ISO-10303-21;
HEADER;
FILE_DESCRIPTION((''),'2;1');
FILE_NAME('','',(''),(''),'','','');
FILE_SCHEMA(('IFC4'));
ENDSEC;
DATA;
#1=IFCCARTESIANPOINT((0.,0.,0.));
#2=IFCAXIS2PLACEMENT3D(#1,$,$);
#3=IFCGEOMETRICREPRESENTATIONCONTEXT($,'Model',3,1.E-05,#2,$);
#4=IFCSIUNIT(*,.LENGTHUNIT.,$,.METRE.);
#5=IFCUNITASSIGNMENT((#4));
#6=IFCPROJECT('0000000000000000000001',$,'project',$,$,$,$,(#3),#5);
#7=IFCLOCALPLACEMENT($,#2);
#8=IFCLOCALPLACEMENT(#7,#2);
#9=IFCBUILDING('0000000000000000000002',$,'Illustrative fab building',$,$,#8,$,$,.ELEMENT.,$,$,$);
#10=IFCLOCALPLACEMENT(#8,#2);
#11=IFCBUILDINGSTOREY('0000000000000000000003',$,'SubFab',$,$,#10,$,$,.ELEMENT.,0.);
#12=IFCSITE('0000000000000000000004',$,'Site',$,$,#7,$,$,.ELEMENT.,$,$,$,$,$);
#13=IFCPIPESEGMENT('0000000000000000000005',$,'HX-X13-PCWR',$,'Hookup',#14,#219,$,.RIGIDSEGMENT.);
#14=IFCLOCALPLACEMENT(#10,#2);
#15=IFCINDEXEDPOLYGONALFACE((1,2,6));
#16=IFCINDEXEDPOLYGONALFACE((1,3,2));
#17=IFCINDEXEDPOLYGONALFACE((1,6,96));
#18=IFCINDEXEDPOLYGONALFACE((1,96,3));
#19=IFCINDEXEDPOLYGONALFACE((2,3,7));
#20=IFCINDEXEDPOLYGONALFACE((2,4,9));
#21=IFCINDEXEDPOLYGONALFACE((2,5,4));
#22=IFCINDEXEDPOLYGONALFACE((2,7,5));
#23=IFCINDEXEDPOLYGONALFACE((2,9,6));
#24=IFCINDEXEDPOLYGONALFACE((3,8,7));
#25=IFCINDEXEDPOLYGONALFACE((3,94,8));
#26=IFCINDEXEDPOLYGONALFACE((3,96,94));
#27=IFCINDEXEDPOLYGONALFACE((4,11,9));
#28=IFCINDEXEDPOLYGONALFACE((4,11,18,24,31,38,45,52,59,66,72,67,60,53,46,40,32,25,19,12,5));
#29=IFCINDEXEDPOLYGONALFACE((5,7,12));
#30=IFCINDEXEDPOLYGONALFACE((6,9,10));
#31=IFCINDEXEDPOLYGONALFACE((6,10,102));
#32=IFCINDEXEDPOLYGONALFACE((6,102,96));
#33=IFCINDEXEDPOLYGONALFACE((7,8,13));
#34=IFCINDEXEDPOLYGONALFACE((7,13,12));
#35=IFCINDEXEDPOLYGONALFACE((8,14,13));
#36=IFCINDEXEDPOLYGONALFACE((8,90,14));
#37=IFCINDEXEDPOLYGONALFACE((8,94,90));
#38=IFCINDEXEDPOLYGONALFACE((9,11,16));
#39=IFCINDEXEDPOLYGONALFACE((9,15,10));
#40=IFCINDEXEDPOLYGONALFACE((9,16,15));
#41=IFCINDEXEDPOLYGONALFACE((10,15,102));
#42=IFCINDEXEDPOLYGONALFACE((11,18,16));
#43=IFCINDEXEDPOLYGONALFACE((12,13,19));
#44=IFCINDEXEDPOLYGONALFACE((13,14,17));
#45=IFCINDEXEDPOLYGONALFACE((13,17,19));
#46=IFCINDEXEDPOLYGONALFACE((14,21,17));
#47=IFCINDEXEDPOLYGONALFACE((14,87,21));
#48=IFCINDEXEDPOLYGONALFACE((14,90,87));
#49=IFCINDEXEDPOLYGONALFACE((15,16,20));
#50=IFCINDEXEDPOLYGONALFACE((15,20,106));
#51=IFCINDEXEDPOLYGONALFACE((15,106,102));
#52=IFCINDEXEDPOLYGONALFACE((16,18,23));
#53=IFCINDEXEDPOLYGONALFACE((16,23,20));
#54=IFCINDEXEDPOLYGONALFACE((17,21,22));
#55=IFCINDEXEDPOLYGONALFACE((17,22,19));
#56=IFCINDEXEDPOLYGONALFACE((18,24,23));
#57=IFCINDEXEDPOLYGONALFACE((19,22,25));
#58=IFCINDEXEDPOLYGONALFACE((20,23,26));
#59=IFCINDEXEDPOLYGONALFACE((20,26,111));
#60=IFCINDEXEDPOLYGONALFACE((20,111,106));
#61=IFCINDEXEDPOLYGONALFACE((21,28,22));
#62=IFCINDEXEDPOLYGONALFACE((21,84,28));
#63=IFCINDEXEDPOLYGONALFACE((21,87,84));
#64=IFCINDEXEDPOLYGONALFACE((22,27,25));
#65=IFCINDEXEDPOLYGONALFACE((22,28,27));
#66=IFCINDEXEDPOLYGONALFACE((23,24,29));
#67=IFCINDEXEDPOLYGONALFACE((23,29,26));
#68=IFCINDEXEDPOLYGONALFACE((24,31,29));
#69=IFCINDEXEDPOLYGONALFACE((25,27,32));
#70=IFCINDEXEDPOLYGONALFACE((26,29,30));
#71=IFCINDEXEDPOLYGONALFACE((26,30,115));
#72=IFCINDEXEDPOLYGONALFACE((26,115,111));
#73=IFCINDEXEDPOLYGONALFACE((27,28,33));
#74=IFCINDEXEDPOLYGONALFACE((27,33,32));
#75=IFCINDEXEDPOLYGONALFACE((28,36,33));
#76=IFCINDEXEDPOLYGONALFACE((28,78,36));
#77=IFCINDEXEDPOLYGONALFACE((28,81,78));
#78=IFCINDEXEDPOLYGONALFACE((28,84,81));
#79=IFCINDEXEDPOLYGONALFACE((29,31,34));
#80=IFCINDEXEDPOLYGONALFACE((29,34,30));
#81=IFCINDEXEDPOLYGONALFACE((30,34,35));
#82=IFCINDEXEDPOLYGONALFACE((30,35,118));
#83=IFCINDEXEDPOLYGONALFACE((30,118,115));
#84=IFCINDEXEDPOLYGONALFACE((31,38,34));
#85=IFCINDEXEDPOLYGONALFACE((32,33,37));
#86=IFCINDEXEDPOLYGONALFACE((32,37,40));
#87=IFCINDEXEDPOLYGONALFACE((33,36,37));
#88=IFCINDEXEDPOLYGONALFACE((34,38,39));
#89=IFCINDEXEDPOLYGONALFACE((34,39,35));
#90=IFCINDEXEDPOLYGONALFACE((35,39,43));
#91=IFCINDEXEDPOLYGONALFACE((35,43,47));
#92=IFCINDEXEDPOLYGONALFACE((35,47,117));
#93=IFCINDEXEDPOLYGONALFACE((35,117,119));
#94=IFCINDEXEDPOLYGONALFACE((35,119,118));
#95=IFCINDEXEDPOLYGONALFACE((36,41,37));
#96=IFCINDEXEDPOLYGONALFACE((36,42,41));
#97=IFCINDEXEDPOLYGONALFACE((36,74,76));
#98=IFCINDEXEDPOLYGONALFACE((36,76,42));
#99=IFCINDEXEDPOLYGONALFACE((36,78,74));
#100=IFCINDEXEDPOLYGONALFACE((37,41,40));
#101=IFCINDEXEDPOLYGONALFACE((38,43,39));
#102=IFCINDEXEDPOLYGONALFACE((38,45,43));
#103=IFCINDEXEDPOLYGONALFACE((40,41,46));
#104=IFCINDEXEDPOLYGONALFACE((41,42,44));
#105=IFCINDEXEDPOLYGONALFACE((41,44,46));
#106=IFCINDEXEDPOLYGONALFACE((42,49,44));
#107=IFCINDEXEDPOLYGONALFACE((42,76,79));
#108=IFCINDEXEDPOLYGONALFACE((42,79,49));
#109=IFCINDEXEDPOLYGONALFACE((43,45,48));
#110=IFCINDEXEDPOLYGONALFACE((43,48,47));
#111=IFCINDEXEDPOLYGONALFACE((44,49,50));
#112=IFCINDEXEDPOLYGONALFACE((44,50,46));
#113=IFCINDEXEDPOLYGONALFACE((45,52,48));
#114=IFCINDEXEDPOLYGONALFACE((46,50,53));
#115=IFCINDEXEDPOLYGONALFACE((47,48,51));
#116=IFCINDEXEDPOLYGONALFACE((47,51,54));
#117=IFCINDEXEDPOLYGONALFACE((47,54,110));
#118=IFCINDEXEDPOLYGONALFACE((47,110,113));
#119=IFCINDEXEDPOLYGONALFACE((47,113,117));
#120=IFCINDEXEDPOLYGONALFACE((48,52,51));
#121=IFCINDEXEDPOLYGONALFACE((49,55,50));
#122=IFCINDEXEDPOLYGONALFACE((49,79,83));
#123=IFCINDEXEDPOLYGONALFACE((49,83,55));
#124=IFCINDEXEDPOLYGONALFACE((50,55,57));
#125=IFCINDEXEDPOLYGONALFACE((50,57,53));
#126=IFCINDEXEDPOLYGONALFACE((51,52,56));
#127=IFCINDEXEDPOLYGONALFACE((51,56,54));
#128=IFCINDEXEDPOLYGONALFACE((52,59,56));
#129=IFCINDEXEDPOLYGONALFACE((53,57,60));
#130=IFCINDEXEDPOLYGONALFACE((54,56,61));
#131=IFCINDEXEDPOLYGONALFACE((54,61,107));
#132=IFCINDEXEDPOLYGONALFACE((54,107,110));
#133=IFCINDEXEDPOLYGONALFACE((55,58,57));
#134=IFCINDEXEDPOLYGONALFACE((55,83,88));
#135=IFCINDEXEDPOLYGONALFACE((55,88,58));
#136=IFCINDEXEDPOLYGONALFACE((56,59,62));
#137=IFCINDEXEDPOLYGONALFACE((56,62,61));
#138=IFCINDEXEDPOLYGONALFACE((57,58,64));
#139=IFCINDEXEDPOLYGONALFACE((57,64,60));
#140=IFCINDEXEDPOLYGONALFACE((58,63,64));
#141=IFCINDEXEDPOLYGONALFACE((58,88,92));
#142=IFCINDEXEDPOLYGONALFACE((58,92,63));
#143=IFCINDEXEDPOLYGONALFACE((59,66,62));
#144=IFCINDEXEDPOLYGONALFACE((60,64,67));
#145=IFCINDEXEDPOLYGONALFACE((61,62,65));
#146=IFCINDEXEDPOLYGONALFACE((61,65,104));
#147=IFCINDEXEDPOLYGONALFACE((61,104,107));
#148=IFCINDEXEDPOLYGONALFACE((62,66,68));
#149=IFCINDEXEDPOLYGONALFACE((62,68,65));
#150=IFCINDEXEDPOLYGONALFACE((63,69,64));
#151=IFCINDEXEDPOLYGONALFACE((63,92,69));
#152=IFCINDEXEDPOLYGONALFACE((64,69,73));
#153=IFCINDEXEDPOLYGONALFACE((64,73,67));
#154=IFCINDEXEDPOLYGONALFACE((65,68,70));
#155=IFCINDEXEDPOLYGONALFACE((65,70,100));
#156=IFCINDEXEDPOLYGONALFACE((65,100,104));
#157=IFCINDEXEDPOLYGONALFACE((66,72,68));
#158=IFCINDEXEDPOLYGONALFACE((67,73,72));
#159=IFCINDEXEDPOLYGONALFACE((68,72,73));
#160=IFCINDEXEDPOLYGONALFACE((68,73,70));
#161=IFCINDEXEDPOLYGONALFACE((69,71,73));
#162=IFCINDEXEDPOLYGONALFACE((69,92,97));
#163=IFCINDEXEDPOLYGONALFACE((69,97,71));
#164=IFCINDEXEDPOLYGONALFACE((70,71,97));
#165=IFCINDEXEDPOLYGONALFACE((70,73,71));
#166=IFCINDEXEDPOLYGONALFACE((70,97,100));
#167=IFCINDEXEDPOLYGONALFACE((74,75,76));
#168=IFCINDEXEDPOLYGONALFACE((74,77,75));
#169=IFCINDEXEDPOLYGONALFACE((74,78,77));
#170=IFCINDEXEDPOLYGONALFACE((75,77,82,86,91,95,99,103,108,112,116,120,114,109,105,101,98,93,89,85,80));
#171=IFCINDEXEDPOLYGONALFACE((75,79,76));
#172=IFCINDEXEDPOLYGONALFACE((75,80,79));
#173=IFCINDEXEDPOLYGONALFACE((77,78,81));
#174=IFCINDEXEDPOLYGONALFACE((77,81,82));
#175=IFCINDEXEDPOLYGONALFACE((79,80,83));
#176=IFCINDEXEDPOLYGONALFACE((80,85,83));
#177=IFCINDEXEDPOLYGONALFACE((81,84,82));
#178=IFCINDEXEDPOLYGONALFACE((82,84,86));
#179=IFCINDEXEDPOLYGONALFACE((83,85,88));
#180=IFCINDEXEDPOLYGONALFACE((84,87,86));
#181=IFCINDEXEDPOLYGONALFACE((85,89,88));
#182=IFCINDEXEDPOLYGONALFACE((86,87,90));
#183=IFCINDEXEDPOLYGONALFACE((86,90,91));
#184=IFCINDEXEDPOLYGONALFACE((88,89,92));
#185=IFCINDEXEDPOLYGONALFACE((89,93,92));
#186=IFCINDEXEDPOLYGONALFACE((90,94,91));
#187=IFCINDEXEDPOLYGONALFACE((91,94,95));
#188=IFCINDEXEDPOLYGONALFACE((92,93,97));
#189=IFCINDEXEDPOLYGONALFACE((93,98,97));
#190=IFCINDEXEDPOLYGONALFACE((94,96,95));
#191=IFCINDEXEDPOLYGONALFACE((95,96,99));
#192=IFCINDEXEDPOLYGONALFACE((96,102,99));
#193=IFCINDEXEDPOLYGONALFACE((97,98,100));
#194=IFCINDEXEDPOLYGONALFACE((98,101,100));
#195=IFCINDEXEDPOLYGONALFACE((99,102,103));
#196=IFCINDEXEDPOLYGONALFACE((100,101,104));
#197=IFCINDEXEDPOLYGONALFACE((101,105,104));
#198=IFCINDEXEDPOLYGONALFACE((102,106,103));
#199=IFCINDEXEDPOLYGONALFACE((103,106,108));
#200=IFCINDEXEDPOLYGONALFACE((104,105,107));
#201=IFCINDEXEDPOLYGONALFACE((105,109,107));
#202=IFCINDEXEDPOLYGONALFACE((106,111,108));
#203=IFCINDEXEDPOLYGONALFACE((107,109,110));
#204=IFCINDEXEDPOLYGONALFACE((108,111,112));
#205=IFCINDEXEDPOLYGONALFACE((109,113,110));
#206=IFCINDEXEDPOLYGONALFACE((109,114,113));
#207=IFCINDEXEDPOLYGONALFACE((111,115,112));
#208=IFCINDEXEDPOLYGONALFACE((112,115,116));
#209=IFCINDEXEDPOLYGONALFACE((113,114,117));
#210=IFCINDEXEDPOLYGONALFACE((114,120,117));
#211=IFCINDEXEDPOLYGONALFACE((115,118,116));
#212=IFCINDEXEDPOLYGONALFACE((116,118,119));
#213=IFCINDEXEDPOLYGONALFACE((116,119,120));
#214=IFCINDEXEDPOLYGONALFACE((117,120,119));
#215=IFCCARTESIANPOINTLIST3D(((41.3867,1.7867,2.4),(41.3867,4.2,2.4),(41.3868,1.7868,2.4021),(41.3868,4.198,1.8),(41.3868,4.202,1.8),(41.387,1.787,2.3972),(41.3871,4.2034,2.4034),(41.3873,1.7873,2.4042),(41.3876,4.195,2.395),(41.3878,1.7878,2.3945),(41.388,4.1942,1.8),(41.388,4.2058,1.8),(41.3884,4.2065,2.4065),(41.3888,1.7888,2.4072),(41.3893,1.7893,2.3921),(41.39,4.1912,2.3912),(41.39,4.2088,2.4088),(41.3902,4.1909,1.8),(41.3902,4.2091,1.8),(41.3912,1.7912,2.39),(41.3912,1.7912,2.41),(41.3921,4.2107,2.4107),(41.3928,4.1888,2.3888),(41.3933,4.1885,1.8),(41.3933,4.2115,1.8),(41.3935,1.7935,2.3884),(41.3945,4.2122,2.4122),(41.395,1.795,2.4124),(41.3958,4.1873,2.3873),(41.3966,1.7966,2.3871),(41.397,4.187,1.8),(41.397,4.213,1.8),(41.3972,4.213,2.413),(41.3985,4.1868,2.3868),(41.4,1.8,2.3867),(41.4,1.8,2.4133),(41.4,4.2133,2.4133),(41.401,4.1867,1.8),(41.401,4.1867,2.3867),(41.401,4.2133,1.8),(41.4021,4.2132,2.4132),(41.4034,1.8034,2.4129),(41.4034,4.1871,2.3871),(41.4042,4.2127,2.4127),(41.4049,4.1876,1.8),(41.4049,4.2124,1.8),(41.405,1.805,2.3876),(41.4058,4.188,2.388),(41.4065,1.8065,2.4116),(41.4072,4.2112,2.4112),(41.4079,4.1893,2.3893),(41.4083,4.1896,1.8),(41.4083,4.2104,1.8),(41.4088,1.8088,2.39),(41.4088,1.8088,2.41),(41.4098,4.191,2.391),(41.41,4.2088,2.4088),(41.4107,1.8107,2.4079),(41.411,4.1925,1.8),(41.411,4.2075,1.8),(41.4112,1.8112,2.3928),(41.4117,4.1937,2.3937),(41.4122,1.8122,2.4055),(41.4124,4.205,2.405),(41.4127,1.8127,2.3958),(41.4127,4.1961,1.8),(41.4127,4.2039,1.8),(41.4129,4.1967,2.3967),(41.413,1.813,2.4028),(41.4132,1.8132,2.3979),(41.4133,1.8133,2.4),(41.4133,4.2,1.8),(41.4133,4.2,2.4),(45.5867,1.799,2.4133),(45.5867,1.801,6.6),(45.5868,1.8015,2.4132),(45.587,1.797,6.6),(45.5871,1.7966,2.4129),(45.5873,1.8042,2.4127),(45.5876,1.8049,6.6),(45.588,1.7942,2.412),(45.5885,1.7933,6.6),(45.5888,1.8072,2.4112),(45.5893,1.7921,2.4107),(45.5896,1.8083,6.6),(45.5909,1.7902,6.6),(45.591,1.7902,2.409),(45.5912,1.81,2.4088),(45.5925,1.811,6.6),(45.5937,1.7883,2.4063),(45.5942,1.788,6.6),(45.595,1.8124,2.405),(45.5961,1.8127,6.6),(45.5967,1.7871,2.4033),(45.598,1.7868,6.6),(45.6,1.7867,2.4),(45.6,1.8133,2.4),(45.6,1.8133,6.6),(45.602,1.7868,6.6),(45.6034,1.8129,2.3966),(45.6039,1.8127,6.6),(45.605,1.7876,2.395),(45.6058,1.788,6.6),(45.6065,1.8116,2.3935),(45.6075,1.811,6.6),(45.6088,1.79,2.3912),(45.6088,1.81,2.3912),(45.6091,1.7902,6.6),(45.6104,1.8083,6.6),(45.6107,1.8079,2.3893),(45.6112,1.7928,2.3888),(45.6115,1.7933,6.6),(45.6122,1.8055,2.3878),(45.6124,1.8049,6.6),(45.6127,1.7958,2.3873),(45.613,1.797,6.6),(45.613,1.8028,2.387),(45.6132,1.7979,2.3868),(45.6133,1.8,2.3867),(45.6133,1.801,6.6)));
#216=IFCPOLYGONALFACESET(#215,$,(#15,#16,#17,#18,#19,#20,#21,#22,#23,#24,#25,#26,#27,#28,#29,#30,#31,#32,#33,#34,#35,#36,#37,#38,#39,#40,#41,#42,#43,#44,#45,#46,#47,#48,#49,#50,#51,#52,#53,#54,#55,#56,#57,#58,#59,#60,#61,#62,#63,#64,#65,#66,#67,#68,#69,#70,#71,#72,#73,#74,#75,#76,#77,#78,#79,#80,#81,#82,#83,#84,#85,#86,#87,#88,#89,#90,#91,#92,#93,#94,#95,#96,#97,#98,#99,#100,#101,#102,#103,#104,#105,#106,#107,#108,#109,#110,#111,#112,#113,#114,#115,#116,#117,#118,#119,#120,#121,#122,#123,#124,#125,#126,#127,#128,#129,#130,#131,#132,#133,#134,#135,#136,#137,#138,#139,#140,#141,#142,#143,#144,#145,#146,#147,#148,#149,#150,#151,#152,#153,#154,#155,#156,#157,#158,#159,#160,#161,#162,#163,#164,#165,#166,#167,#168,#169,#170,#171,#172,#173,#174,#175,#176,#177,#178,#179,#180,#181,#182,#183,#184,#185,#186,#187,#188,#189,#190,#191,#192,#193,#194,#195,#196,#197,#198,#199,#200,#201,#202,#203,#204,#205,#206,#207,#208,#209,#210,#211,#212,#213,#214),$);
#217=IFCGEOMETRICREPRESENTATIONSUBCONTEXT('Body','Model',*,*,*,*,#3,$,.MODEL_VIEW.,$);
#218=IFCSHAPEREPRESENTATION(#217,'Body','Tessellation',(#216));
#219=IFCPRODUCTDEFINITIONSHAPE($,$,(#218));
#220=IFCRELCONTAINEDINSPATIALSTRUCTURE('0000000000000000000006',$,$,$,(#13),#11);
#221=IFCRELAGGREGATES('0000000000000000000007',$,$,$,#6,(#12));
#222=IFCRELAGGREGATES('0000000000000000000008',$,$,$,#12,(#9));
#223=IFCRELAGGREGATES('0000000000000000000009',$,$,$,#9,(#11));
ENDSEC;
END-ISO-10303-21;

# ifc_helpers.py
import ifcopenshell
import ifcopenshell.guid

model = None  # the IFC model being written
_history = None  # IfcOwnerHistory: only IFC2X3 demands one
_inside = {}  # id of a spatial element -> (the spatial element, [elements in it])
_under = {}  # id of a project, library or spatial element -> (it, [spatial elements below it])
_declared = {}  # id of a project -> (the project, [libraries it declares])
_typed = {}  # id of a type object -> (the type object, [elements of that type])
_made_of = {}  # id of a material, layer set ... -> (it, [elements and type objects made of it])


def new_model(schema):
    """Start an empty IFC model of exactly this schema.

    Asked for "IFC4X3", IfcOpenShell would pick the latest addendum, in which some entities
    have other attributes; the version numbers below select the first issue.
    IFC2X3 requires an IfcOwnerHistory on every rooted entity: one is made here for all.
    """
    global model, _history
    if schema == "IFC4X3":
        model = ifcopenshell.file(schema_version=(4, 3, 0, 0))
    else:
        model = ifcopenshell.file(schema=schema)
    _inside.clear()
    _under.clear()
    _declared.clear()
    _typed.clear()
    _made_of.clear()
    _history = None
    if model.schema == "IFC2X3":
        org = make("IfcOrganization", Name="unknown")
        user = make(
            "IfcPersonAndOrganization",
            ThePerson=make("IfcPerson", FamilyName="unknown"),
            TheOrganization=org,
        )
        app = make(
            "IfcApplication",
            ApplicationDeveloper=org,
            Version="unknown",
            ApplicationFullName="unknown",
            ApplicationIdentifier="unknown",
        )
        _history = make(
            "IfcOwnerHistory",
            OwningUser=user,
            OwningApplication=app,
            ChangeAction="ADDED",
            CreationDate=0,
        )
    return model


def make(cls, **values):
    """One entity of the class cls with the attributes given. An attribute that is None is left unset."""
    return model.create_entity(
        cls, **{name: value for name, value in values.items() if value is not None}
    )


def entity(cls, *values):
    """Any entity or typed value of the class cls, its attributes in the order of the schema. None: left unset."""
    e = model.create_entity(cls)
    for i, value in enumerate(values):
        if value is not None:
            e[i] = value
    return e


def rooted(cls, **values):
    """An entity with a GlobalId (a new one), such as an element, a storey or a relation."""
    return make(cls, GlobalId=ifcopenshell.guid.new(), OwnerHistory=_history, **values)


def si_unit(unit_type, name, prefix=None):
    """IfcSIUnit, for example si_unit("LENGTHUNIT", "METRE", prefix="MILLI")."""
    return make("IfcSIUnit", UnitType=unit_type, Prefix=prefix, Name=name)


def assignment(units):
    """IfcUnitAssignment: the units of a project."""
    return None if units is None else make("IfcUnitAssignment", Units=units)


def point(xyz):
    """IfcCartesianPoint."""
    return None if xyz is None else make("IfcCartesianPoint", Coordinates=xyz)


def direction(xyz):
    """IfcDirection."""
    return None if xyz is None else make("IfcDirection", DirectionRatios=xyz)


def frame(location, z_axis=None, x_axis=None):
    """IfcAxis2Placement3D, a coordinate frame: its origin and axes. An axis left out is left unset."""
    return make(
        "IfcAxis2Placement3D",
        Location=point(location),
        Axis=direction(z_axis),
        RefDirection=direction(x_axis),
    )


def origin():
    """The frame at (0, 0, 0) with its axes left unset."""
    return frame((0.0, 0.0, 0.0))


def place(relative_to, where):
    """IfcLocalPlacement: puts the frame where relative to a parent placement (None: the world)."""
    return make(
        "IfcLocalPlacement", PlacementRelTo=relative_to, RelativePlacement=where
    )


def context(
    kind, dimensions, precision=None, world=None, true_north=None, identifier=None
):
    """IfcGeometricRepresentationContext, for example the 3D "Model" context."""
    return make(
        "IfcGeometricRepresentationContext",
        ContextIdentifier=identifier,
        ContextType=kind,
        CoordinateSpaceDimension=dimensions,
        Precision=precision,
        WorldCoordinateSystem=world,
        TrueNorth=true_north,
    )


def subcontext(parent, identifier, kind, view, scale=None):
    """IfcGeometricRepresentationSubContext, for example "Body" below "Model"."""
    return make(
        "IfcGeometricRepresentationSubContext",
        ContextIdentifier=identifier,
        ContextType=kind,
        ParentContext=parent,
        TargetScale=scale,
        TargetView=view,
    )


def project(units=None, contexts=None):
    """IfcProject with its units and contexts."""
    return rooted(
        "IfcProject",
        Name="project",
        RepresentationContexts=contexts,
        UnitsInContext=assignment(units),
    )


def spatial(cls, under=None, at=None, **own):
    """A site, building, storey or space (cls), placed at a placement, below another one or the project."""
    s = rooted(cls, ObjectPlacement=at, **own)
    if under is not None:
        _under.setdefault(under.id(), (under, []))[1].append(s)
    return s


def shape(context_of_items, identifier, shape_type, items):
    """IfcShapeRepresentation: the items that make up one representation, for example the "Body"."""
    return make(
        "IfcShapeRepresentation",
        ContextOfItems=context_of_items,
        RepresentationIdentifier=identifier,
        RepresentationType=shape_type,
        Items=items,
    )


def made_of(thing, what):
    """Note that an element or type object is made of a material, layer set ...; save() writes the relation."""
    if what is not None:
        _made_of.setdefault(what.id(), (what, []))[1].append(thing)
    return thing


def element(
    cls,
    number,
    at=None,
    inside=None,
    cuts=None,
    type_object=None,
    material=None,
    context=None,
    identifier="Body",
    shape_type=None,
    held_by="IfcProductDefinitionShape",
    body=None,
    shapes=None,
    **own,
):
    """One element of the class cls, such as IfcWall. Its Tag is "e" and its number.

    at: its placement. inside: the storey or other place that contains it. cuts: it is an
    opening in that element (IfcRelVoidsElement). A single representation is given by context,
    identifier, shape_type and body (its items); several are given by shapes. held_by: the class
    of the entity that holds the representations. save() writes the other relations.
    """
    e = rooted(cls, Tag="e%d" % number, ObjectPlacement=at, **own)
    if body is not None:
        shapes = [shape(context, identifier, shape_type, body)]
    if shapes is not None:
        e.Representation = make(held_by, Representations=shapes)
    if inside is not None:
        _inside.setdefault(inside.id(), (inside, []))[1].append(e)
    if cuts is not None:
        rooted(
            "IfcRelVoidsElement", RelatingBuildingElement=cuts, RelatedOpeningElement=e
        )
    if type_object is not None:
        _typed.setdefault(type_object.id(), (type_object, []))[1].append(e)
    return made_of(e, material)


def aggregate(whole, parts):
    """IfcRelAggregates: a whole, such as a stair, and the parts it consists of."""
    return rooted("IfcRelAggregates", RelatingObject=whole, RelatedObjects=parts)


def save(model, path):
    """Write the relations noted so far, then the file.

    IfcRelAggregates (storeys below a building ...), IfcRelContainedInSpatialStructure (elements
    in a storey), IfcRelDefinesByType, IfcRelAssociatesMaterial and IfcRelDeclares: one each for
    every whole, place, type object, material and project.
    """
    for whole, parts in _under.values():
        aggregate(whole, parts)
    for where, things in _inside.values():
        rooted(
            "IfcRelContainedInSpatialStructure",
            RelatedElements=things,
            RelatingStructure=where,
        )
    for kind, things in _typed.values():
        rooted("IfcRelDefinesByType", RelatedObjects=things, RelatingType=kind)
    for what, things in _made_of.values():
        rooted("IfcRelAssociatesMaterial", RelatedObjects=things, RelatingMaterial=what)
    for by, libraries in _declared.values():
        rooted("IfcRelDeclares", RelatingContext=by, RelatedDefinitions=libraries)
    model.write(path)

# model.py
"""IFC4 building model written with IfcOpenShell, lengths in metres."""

from ifc_helpers import new_model, entity, si_unit, origin, place, context, subcontext, project, spatial, element, save


model = new_model("IFC4")

# Units and contexts
model_context = context("Model", 3, precision=1e-05, world=origin())
body_context = subcontext(model_context, "Body", "Model", "MODEL_VIEW")
ifc_project = project(units=[si_unit("LENGTHUNIT", "METRE")], contexts=[model_context])

# Site, building, storey
site_placement = place(None, origin())
site = spatial("IfcSite", under=ifc_project, at=site_placement, Name="Site", CompositionType="ELEMENT")
building_placement = place(site_placement, origin())
building = spatial("IfcBuilding", under=site, at=building_placement, Name="Illustrative fab building", CompositionType="ELEMENT")
storey_placement = place(building_placement, origin())
storey = spatial("IfcBuildingStorey", under=building, at=storey_placement, Name="SubFab", CompositionType="ELEMENT", Elevation=0.0)

# Pipe segment
pipe_segment_1_placement = place(storey_placement, origin())
element("IfcPipeSegment", 1, at=pipe_segment_1_placement, inside=storey, Name="HX-X13-PCWR", ObjectType="Hookup", PredefinedType="RIGIDSEGMENT", context=body_context, shape_type="AdvancedSweptSolid", body=[
    entity("IfcSweptDiskSolid", entity("IfcPolyline", [entity("IfcCartesianPoint", [41.4, 4.2, 1.8]), entity("IfcCartesianPoint", [41.4, 4.2, 2.4]), entity("IfcCartesianPoint", [41.4, 1.8, 2.4]), entity("IfcCartesianPoint", [45.6, 1.8, 2.4]), entity("IfcCartesianPoint", [45.6, 1.8, 6.6])]), 0.0133),
])

save(model, "model.ifc")
